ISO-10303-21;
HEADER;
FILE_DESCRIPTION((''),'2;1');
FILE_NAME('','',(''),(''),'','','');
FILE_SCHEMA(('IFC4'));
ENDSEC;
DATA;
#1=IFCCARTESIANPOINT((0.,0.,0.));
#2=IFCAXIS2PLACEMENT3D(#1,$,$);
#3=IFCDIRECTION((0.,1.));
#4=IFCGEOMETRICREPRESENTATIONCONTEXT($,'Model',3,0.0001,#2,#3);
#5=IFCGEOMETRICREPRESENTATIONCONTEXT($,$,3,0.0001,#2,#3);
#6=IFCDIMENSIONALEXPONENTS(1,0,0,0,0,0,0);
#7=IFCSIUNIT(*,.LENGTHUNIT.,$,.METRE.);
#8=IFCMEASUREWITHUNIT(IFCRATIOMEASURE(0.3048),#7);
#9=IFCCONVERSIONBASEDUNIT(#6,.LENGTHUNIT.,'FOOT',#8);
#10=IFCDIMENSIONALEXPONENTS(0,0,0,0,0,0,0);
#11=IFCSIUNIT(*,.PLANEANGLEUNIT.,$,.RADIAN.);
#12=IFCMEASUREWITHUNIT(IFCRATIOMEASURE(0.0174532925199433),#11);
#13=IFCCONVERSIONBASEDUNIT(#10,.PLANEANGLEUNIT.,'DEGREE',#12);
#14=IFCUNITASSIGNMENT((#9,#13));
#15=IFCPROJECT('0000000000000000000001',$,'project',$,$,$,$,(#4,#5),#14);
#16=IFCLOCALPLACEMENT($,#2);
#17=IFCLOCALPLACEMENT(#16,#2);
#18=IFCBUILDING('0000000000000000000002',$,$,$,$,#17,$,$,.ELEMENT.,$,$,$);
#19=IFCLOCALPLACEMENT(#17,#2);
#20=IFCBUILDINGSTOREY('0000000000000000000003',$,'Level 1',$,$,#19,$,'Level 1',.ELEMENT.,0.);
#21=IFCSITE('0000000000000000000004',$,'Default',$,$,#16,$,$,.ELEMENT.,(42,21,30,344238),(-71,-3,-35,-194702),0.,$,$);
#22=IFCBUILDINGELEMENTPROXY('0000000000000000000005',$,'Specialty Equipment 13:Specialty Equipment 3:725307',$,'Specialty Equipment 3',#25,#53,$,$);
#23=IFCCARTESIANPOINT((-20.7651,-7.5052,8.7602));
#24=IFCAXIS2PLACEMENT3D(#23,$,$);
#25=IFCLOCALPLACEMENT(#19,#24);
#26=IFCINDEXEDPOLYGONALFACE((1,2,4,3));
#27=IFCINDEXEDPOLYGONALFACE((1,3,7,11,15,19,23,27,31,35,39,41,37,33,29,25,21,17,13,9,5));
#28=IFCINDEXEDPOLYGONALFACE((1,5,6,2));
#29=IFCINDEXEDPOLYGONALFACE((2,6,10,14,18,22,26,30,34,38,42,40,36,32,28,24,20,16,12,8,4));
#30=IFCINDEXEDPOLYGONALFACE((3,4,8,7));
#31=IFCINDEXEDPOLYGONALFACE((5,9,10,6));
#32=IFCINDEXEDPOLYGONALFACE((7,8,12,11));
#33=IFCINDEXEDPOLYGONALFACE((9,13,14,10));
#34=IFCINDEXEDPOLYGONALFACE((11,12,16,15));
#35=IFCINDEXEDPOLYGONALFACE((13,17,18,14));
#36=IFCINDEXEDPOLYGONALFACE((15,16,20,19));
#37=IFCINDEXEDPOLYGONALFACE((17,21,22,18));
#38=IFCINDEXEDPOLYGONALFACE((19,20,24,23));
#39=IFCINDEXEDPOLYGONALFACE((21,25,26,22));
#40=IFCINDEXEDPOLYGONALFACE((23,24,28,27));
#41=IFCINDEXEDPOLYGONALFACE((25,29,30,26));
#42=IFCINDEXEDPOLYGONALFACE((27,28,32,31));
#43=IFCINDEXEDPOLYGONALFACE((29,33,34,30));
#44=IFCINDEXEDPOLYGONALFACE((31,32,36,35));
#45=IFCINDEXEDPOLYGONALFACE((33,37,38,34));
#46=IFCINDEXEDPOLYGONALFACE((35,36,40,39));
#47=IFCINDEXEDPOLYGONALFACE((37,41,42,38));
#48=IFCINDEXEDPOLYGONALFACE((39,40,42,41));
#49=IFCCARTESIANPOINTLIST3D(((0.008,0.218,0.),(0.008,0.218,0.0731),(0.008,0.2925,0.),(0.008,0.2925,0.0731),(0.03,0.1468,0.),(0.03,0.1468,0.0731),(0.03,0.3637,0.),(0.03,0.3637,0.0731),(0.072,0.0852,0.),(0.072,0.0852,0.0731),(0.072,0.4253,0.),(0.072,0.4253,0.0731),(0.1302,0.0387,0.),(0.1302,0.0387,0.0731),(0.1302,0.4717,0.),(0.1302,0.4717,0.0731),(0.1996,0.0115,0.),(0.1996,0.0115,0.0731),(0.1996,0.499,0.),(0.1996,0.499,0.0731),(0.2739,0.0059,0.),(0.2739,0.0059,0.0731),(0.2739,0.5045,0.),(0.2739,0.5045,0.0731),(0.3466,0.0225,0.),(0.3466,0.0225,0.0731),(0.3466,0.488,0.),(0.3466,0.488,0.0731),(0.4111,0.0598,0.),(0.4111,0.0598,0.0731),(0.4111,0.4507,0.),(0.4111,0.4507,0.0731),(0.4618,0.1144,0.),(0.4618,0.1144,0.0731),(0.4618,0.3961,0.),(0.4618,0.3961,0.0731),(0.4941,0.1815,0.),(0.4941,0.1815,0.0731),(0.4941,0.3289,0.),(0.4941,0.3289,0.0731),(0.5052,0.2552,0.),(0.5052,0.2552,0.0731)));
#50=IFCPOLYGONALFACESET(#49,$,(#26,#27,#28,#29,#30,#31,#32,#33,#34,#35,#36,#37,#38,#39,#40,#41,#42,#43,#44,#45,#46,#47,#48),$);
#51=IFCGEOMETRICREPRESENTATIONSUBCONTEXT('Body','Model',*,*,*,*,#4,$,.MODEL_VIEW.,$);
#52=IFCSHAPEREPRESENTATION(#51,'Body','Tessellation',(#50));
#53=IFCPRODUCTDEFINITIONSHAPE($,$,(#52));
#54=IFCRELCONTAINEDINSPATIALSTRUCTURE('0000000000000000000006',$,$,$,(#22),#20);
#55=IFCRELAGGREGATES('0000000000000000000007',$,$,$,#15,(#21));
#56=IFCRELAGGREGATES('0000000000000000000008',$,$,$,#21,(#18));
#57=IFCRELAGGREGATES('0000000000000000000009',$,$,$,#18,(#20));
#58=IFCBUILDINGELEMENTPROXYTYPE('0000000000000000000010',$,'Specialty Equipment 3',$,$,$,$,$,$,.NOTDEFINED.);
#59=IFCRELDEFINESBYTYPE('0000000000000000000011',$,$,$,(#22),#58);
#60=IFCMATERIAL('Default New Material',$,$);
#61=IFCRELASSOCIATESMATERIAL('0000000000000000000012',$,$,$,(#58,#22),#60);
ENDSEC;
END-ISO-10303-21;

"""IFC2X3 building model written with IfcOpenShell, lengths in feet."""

from ifc_helpers import new_model, entity, si_unit, converted_unit, direction, frame, frame_2d, origin, place, context, subcontext, project, spatial, circle, extrude, source, transform, mapped, material, type_object, type_shapes, element, save


model = new_model("IFC2X3")

# Units and contexts
model_context = context("Model", 3, precision=0.0001, world=origin(), true_north=direction((0.0, 1.0)))
context_of_model = context(None, 3, precision=0.0001, world=origin(), true_north=direction((0.0, 1.0)))
body_context = subcontext(model_context, "Body", "Model", "MODEL_VIEW")
ifc_project = project(units=[converted_unit("LENGTHUNIT", "FOOT", entity("IfcRatioMeasure", 0.3048), si_unit("LENGTHUNIT", "METRE"), dimensions=[1, 0, 0, 0, 0, 0, 0]), converted_unit("PLANEANGLEUNIT", "DEGREE", entity("IfcRatioMeasure", 0.0174532925199433), si_unit("PLANEANGLEUNIT", "RADIAN"), dimensions=[0, 0, 0, 0, 0, 0, 0])], contexts=[model_context, context_of_model])

# Site, building, storey
site_placement = place(None, origin())
site = spatial("IfcSite", under=ifc_project, at=site_placement, Name="Default", CompositionType="ELEMENT", RefLatitude=(42, 21, 30, 344238), RefLongitude=(-71, -3, -35, -194702), RefElevation=0.0)
building_placement = place(site_placement, origin())
building = spatial("IfcBuilding", under=site, at=building_placement, CompositionType="ELEMENT")
storey_placement = place(building_placement, origin())
storey = spatial("IfcBuildingStorey", under=building, at=storey_placement, Name="Level 1", LongName="Level 1", CompositionType="ELEMENT", Elevation=0.0)

# Shared definitions
ifc_material = material(Name="Default New Material")

# Building element proxy
building_element_proxy_type_1 = type_object("IfcBuildingElementProxyType", Name="Specialty Equipment 3", PredefinedType="NOTDEFINED", material=ifc_material)
shared_shape_1 = source(origin(), body_context, "Body", "SweptSolid", [
    extrude(circle(Radius=0.25, at=frame_2d((0.0, 0.0), x_axis=(1.0, 0.0))), frame((0.2552, 0.2552, 0.0)), (0.0, 0.0, 1.0), 0.0731),
])
type_shapes(building_element_proxy_type_1, [shared_shape_1])
proxy_1_placement = place(storey_placement, frame((-20.7651, -7.5052, 8.7602)))
element("IfcBuildingElementProxy", 1, at=proxy_1_placement, inside=storey, type_object=building_element_proxy_type_1, material=ifc_material, Name="Specialty Equipment 13:Specialty Equipment 3:725307", ObjectType="Specialty Equipment 3", context=body_context, shape_type="MappedRepresentation", body=[
    mapped(shared_shape_1, transform((0.0, 0.0, 0.0), scale=1.0)),
])

save(model, "model.ifc")
